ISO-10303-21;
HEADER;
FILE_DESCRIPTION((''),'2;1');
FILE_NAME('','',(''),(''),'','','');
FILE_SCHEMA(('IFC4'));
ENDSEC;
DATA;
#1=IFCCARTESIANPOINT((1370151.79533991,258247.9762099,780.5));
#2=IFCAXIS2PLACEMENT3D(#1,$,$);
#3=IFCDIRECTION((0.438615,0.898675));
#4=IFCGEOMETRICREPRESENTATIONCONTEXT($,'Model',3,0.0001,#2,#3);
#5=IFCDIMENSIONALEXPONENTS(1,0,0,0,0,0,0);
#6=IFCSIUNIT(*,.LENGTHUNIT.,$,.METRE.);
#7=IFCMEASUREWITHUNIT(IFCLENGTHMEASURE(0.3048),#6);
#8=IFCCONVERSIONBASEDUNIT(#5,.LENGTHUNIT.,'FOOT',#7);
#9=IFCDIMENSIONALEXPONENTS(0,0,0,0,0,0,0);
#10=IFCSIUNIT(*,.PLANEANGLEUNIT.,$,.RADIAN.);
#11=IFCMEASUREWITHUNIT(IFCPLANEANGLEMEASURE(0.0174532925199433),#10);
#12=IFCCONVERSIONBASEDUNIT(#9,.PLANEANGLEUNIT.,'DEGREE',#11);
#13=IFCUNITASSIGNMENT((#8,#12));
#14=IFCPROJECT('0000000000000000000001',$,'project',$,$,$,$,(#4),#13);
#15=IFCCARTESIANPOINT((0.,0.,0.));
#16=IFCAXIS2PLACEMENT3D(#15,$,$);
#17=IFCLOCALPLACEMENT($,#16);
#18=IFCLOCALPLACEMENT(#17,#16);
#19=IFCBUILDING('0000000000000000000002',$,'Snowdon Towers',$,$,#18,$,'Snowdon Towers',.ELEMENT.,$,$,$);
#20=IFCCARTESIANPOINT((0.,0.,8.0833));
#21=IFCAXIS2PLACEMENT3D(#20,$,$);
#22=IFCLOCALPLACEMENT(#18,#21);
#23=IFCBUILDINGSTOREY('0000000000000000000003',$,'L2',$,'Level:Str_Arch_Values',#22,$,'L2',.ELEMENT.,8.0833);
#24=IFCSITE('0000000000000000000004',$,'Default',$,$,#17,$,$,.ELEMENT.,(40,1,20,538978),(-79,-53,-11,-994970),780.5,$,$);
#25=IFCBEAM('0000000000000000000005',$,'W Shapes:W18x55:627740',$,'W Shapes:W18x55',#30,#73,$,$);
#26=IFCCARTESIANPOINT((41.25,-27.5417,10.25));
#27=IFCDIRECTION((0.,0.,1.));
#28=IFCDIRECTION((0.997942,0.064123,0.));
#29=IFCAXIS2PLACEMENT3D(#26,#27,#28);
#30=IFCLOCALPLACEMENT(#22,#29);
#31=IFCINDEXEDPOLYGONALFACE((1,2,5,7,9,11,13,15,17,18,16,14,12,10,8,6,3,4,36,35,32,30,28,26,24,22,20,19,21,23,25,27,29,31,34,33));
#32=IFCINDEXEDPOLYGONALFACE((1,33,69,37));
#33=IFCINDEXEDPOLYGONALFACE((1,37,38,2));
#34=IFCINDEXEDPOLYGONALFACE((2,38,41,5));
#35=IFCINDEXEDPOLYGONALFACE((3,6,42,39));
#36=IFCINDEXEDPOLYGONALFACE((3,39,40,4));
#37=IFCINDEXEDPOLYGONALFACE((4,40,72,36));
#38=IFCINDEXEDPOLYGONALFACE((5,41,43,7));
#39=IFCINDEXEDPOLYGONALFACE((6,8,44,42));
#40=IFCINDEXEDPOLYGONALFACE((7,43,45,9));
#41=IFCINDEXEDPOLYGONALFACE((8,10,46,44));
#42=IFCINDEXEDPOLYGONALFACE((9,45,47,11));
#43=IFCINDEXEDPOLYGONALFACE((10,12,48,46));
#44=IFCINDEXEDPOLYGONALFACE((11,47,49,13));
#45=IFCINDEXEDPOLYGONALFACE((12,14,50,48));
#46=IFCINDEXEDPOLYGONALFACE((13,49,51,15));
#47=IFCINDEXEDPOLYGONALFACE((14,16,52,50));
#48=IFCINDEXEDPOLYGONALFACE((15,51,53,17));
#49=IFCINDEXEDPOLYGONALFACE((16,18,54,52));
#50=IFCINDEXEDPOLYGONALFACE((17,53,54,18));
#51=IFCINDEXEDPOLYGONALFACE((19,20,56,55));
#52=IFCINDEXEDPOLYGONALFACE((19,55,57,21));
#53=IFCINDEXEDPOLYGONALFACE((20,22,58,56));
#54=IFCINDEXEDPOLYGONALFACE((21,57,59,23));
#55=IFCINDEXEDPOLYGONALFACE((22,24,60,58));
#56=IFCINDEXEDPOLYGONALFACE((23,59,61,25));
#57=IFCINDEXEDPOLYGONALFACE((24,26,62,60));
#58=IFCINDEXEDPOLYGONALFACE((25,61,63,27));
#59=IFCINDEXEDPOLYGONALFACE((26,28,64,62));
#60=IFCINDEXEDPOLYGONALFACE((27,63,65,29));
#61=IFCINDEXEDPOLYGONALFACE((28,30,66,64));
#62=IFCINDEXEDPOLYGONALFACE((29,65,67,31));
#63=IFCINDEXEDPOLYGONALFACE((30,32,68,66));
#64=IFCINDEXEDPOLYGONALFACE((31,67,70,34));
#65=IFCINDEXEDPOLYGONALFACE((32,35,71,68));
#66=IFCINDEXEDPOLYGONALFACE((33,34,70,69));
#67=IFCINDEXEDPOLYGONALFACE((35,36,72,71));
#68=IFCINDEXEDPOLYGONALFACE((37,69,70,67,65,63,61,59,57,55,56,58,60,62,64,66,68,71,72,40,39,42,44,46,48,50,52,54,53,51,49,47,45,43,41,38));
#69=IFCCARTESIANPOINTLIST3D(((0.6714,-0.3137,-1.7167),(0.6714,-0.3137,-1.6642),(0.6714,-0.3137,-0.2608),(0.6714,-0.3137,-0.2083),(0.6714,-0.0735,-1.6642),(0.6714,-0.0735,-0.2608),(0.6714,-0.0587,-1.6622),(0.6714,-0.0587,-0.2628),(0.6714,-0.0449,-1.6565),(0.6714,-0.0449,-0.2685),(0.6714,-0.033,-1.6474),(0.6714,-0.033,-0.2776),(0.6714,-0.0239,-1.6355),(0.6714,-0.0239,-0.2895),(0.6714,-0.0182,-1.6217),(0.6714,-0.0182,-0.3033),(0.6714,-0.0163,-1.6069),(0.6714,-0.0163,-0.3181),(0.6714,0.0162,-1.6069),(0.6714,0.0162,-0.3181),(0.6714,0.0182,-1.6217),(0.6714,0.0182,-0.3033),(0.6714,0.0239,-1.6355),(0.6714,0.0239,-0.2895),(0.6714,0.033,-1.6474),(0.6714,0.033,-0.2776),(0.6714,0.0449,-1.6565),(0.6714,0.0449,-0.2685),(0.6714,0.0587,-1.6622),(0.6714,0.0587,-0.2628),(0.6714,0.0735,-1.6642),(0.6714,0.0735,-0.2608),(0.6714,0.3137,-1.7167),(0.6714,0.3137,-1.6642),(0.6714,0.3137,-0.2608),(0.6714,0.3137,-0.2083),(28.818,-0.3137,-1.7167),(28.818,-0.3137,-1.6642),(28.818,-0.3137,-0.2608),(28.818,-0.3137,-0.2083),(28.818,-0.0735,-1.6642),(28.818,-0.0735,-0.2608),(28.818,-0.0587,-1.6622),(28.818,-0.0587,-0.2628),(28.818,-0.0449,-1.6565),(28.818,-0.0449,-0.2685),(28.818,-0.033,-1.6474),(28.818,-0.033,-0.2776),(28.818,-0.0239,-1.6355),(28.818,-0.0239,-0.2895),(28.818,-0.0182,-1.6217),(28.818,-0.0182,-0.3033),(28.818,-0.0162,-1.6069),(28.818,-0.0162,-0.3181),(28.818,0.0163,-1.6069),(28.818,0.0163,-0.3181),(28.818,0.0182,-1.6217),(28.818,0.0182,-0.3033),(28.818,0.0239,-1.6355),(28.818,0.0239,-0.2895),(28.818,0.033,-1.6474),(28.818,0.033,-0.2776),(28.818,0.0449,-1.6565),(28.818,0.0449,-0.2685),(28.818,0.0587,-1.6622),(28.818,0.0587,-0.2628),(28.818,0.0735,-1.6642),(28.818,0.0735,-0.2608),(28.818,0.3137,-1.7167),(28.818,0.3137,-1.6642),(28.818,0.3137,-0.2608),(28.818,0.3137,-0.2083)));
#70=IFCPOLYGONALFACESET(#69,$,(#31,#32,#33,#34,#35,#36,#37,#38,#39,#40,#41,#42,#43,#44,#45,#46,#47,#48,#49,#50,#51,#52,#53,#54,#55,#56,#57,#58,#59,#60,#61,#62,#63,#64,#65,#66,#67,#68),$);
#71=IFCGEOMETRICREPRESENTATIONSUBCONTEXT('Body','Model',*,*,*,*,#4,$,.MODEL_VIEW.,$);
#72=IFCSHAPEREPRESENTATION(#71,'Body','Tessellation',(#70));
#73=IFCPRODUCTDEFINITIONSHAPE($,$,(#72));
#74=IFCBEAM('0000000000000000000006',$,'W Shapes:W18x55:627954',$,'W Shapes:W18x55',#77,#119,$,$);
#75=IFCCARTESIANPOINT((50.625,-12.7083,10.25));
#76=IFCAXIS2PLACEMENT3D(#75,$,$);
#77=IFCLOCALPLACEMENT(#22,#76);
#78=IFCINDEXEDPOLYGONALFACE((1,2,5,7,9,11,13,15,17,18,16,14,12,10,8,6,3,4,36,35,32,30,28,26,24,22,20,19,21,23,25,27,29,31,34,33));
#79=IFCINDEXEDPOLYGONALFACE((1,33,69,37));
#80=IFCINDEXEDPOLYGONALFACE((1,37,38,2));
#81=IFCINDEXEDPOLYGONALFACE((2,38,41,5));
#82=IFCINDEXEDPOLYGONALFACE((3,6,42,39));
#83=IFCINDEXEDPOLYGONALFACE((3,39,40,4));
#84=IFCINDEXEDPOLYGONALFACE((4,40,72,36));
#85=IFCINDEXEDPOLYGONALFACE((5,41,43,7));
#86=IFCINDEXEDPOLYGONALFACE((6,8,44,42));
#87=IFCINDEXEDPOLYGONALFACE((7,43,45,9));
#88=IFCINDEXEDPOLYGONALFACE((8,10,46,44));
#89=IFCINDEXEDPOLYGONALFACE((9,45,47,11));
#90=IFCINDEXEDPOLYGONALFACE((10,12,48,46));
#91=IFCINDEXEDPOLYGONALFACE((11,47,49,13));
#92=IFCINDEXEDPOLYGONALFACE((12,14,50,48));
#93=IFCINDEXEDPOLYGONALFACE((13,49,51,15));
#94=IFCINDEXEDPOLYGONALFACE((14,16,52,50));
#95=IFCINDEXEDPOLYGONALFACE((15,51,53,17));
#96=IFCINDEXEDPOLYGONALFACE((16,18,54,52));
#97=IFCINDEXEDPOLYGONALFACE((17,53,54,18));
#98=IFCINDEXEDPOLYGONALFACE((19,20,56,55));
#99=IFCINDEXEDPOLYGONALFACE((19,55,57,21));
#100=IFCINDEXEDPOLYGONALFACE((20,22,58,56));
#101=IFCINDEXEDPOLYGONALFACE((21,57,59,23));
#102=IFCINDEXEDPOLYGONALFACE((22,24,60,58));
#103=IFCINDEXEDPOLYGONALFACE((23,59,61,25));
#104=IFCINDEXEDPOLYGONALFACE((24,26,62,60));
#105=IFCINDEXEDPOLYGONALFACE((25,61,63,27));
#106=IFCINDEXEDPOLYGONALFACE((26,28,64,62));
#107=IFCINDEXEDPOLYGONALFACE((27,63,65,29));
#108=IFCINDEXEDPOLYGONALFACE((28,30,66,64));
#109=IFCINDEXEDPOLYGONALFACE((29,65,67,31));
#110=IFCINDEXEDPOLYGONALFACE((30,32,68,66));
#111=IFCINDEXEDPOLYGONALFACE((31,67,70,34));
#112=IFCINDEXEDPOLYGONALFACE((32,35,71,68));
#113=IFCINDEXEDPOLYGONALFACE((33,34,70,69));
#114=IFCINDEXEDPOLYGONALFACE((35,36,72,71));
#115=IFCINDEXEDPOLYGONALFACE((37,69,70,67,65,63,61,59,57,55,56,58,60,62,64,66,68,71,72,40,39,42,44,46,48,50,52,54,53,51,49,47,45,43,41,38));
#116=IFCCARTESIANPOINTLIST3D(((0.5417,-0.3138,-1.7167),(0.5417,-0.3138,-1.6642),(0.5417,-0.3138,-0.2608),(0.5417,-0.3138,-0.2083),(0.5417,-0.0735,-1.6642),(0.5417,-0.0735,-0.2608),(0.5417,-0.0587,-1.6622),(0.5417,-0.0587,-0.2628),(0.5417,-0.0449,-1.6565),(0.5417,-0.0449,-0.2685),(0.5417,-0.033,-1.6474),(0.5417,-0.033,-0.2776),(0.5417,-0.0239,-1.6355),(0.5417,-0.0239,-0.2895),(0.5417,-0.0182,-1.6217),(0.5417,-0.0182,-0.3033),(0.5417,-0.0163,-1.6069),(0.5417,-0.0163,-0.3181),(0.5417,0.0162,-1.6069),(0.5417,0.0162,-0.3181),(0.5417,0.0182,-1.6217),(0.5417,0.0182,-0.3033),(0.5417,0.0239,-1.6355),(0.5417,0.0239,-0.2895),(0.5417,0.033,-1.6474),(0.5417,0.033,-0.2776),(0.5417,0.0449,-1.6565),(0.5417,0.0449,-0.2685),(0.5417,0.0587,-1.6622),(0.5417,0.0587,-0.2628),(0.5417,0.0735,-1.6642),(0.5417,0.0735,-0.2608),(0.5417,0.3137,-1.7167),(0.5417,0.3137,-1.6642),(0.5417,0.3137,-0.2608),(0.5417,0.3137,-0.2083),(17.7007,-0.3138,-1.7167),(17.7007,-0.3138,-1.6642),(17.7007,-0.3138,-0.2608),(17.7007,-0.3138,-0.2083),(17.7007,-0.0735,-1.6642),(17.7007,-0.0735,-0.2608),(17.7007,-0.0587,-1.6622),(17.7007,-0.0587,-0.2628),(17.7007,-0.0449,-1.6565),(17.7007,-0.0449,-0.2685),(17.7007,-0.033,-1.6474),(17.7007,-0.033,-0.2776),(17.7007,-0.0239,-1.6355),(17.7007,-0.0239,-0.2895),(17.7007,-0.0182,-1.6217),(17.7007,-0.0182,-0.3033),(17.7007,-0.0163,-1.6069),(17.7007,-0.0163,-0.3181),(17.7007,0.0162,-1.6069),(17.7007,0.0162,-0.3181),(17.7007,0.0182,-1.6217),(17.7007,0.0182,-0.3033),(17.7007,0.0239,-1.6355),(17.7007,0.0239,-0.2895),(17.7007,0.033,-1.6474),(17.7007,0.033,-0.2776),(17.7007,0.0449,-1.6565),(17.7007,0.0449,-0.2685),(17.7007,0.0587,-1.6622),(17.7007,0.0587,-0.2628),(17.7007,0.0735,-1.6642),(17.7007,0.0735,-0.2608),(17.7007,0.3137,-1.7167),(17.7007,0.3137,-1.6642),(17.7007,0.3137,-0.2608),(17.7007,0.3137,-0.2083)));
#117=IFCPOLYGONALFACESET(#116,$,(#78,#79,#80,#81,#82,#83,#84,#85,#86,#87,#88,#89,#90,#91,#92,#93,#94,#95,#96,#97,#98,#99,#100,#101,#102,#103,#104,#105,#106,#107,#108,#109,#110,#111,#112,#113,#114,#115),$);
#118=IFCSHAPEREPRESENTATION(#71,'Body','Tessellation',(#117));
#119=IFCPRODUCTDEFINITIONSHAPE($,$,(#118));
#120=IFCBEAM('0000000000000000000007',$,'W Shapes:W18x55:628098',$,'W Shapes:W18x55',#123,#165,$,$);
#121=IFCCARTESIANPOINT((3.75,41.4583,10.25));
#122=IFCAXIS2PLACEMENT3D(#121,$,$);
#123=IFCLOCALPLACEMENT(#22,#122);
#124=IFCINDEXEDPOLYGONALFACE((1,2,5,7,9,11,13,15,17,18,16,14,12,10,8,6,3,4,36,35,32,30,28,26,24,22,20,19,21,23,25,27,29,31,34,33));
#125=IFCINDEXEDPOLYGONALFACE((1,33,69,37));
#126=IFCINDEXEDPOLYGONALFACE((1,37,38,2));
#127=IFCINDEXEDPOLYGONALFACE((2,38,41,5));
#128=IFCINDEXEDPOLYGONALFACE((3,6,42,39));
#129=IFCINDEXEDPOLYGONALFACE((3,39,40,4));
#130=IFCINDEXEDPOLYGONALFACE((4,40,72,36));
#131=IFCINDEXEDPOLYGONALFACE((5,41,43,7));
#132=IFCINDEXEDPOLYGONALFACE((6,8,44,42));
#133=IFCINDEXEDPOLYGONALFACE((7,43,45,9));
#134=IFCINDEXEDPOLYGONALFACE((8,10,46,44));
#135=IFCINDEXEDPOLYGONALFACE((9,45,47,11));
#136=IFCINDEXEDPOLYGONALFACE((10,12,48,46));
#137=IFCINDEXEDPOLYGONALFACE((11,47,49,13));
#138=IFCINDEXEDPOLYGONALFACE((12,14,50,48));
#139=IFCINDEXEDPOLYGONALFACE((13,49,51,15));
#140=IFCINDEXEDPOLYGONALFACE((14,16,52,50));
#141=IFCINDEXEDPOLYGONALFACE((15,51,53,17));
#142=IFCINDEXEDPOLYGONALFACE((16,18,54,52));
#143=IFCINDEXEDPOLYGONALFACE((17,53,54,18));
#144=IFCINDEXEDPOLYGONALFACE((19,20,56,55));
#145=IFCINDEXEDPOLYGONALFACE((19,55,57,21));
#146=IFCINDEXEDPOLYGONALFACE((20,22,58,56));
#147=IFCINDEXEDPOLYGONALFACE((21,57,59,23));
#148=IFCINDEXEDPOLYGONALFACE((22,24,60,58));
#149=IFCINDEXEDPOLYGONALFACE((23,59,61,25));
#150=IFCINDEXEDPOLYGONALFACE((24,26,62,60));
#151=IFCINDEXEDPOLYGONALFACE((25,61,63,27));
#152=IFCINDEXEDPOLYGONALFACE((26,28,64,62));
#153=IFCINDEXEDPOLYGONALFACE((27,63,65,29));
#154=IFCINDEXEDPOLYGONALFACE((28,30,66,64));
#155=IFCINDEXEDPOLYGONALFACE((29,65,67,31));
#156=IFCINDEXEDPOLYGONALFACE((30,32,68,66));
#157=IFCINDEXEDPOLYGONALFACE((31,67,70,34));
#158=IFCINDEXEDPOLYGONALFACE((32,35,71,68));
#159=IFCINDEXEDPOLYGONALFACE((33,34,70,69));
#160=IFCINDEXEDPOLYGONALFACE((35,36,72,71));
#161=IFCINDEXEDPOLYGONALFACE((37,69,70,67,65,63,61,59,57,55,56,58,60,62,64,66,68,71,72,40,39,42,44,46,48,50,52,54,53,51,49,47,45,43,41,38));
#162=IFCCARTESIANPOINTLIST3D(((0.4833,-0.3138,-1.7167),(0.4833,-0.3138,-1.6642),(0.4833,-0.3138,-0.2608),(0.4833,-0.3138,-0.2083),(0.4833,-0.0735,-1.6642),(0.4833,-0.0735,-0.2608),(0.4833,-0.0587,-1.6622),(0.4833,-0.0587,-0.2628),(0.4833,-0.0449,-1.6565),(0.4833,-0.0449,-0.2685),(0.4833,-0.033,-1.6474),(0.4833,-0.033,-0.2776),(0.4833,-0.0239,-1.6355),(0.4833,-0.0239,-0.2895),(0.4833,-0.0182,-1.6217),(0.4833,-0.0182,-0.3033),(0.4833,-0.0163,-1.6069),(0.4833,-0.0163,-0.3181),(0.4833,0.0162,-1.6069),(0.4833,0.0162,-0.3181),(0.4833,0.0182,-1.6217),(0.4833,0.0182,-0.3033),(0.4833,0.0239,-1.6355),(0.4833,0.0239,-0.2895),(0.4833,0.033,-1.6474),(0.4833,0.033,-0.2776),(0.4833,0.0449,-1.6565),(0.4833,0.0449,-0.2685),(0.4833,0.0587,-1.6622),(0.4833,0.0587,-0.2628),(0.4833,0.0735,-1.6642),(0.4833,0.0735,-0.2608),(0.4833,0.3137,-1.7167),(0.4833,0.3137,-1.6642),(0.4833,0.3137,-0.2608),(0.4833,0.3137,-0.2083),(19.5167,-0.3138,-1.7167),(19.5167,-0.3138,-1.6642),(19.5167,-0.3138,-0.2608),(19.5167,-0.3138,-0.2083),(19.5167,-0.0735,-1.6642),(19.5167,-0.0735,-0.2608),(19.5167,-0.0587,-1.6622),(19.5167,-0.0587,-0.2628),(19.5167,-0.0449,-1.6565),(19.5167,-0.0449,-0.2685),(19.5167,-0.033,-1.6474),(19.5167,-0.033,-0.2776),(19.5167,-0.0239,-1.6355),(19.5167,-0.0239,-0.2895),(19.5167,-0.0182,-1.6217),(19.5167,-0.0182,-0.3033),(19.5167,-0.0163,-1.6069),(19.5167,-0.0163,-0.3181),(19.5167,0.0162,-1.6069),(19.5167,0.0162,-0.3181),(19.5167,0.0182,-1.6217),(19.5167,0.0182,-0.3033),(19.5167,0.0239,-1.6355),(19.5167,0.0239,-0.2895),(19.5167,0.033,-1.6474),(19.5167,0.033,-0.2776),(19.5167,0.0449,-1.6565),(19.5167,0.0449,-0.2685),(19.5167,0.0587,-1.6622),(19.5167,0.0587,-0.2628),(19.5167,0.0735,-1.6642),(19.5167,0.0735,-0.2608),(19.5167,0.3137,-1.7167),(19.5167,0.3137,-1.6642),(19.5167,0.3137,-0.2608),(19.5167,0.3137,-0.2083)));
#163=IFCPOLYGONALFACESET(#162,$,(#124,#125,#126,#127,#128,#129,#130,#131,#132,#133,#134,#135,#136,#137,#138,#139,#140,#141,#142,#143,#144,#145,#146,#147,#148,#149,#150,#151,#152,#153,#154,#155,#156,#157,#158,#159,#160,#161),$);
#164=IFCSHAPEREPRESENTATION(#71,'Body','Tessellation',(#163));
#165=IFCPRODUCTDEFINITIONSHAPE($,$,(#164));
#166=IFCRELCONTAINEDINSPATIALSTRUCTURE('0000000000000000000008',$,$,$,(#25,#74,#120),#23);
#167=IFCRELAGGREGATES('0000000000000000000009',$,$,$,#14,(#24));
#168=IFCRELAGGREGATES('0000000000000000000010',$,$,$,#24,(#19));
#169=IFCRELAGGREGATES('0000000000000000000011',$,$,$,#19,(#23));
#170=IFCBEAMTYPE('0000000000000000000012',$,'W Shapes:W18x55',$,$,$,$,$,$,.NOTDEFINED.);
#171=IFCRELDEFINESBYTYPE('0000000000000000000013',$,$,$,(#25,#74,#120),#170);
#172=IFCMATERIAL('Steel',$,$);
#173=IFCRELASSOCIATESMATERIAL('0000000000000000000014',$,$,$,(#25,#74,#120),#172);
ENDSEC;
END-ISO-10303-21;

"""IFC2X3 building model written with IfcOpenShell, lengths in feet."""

from ifc_helpers import new_model, entity, si_unit, converted_unit, direction, frame, frame_2d, origin, place, context, subcontext, project, spatial, i_section, extrude, material, type_object, element, save


model = new_model("IFC2X3")

# Units and contexts
model_context = context("Model", 3, precision=0.0001, world=frame((1370151.79533991, 258247.9762099, 780.5)), true_north=direction((0.438615, 0.898675)))
body_context = subcontext(model_context, "Body", "Model", "MODEL_VIEW")
ifc_project = project(units=[converted_unit("LENGTHUNIT", "FOOT", entity("IfcLengthMeasure", 0.3048), si_unit("LENGTHUNIT", "METRE"), dimensions=[1, 0, 0, 0, 0, 0, 0]), converted_unit("PLANEANGLEUNIT", "DEGREE", entity("IfcPlaneAngleMeasure", 0.0174532925199433), si_unit("PLANEANGLEUNIT", "RADIAN"), dimensions=[0, 0, 0, 0, 0, 0, 0])], contexts=[model_context])

# Site, building, storey
site_placement = place(None, origin())
site = spatial("IfcSite", under=ifc_project, at=site_placement, Name="Default", CompositionType="ELEMENT", RefLatitude=(40, 1, 20, 538978), RefLongitude=(-79, -53, -11, -994970), RefElevation=780.5)
building_placement = place(site_placement, origin())
building = spatial("IfcBuilding", under=site, at=building_placement, Name="Snowdon Towers", LongName="Snowdon Towers", CompositionType="ELEMENT")
storey_placement = place(building_placement, frame((0.0, 0.0, 8.0833)))
storey = spatial("IfcBuildingStorey", under=building, at=storey_placement, Name="L2", ObjectType="Level:Str_Arch_Values", LongName="L2", CompositionType="ELEMENT", Elevation=8.0833)

# Beams
ifc_material = material(Name="Steel")
beam_type_1 = type_object("IfcBeamType", Name="W Shapes:W18x55", PredefinedType="NOTDEFINED")
beam_1_placement = place(storey_placement, frame((41.25, -27.5417, 10.25), z_axis=(0.0, 0.0, 1.0), x_axis=(0.997942, 0.064123, 0.0)))
element("IfcBeam", 1, at=beam_1_placement, inside=storey, type_object=beam_type_1, material=ifc_material, Name="W Shapes:W18x55:627740", ObjectType="W Shapes:W18x55", context=body_context, shape_type="SweptSolid", body=[
    extrude(i_section(OverallWidth=0.6275, OverallDepth=1.5083, WebThickness=0.0325, FlangeThickness=0.0525, FilletRadius=0.0573, at=frame_2d((0.0, 0.0), x_axis=(0.0, 1.0))), frame((0.6714, 0.0, -0.9625), z_axis=(1.0, 0.0, 0.0), x_axis=(0.0, 0.0, -1.0)), (0.0, 0.0, 1.0), 28.1466),
])
beam_2_placement = place(storey_placement, frame((50.625, -12.7083, 10.25)))
element("IfcBeam", 2, at=beam_2_placement, inside=storey, type_object=beam_type_1, material=ifc_material, Name="W Shapes:W18x55:627954", ObjectType="W Shapes:W18x55", context=body_context, shape_type="SweptSolid", body=[
    extrude(i_section(OverallWidth=0.6275, OverallDepth=1.5083, WebThickness=0.0325, FlangeThickness=0.0525, FilletRadius=0.0573, at=frame_2d((0.0, 0.0), x_axis=(0.0, 1.0))), frame((0.5417, 0.0, -0.9625), z_axis=(1.0, 0.0, 0.0), x_axis=(0.0, 0.0, -1.0)), (0.0, 0.0, 1.0), 17.159),
])
beam_3_placement = place(storey_placement, frame((3.75, 41.4583, 10.25)))
element("IfcBeam", 3, at=beam_3_placement, inside=storey, type_object=beam_type_1, material=ifc_material, Name="W Shapes:W18x55:628098", ObjectType="W Shapes:W18x55", context=body_context, shape_type="SweptSolid", body=[
    extrude(i_section(OverallWidth=0.6275, OverallDepth=1.5083, WebThickness=0.0325, FlangeThickness=0.0525, FilletRadius=0.0573, at=frame_2d((0.0, 0.0), x_axis=(0.0, 1.0))), frame((0.4833, 0.0, -0.9625), z_axis=(1.0, 0.0, 0.0), x_axis=(0.0, 0.0, -1.0)), (0.0, 0.0, 1.0), 19.0333),
])

save(model, "model.ifc")
